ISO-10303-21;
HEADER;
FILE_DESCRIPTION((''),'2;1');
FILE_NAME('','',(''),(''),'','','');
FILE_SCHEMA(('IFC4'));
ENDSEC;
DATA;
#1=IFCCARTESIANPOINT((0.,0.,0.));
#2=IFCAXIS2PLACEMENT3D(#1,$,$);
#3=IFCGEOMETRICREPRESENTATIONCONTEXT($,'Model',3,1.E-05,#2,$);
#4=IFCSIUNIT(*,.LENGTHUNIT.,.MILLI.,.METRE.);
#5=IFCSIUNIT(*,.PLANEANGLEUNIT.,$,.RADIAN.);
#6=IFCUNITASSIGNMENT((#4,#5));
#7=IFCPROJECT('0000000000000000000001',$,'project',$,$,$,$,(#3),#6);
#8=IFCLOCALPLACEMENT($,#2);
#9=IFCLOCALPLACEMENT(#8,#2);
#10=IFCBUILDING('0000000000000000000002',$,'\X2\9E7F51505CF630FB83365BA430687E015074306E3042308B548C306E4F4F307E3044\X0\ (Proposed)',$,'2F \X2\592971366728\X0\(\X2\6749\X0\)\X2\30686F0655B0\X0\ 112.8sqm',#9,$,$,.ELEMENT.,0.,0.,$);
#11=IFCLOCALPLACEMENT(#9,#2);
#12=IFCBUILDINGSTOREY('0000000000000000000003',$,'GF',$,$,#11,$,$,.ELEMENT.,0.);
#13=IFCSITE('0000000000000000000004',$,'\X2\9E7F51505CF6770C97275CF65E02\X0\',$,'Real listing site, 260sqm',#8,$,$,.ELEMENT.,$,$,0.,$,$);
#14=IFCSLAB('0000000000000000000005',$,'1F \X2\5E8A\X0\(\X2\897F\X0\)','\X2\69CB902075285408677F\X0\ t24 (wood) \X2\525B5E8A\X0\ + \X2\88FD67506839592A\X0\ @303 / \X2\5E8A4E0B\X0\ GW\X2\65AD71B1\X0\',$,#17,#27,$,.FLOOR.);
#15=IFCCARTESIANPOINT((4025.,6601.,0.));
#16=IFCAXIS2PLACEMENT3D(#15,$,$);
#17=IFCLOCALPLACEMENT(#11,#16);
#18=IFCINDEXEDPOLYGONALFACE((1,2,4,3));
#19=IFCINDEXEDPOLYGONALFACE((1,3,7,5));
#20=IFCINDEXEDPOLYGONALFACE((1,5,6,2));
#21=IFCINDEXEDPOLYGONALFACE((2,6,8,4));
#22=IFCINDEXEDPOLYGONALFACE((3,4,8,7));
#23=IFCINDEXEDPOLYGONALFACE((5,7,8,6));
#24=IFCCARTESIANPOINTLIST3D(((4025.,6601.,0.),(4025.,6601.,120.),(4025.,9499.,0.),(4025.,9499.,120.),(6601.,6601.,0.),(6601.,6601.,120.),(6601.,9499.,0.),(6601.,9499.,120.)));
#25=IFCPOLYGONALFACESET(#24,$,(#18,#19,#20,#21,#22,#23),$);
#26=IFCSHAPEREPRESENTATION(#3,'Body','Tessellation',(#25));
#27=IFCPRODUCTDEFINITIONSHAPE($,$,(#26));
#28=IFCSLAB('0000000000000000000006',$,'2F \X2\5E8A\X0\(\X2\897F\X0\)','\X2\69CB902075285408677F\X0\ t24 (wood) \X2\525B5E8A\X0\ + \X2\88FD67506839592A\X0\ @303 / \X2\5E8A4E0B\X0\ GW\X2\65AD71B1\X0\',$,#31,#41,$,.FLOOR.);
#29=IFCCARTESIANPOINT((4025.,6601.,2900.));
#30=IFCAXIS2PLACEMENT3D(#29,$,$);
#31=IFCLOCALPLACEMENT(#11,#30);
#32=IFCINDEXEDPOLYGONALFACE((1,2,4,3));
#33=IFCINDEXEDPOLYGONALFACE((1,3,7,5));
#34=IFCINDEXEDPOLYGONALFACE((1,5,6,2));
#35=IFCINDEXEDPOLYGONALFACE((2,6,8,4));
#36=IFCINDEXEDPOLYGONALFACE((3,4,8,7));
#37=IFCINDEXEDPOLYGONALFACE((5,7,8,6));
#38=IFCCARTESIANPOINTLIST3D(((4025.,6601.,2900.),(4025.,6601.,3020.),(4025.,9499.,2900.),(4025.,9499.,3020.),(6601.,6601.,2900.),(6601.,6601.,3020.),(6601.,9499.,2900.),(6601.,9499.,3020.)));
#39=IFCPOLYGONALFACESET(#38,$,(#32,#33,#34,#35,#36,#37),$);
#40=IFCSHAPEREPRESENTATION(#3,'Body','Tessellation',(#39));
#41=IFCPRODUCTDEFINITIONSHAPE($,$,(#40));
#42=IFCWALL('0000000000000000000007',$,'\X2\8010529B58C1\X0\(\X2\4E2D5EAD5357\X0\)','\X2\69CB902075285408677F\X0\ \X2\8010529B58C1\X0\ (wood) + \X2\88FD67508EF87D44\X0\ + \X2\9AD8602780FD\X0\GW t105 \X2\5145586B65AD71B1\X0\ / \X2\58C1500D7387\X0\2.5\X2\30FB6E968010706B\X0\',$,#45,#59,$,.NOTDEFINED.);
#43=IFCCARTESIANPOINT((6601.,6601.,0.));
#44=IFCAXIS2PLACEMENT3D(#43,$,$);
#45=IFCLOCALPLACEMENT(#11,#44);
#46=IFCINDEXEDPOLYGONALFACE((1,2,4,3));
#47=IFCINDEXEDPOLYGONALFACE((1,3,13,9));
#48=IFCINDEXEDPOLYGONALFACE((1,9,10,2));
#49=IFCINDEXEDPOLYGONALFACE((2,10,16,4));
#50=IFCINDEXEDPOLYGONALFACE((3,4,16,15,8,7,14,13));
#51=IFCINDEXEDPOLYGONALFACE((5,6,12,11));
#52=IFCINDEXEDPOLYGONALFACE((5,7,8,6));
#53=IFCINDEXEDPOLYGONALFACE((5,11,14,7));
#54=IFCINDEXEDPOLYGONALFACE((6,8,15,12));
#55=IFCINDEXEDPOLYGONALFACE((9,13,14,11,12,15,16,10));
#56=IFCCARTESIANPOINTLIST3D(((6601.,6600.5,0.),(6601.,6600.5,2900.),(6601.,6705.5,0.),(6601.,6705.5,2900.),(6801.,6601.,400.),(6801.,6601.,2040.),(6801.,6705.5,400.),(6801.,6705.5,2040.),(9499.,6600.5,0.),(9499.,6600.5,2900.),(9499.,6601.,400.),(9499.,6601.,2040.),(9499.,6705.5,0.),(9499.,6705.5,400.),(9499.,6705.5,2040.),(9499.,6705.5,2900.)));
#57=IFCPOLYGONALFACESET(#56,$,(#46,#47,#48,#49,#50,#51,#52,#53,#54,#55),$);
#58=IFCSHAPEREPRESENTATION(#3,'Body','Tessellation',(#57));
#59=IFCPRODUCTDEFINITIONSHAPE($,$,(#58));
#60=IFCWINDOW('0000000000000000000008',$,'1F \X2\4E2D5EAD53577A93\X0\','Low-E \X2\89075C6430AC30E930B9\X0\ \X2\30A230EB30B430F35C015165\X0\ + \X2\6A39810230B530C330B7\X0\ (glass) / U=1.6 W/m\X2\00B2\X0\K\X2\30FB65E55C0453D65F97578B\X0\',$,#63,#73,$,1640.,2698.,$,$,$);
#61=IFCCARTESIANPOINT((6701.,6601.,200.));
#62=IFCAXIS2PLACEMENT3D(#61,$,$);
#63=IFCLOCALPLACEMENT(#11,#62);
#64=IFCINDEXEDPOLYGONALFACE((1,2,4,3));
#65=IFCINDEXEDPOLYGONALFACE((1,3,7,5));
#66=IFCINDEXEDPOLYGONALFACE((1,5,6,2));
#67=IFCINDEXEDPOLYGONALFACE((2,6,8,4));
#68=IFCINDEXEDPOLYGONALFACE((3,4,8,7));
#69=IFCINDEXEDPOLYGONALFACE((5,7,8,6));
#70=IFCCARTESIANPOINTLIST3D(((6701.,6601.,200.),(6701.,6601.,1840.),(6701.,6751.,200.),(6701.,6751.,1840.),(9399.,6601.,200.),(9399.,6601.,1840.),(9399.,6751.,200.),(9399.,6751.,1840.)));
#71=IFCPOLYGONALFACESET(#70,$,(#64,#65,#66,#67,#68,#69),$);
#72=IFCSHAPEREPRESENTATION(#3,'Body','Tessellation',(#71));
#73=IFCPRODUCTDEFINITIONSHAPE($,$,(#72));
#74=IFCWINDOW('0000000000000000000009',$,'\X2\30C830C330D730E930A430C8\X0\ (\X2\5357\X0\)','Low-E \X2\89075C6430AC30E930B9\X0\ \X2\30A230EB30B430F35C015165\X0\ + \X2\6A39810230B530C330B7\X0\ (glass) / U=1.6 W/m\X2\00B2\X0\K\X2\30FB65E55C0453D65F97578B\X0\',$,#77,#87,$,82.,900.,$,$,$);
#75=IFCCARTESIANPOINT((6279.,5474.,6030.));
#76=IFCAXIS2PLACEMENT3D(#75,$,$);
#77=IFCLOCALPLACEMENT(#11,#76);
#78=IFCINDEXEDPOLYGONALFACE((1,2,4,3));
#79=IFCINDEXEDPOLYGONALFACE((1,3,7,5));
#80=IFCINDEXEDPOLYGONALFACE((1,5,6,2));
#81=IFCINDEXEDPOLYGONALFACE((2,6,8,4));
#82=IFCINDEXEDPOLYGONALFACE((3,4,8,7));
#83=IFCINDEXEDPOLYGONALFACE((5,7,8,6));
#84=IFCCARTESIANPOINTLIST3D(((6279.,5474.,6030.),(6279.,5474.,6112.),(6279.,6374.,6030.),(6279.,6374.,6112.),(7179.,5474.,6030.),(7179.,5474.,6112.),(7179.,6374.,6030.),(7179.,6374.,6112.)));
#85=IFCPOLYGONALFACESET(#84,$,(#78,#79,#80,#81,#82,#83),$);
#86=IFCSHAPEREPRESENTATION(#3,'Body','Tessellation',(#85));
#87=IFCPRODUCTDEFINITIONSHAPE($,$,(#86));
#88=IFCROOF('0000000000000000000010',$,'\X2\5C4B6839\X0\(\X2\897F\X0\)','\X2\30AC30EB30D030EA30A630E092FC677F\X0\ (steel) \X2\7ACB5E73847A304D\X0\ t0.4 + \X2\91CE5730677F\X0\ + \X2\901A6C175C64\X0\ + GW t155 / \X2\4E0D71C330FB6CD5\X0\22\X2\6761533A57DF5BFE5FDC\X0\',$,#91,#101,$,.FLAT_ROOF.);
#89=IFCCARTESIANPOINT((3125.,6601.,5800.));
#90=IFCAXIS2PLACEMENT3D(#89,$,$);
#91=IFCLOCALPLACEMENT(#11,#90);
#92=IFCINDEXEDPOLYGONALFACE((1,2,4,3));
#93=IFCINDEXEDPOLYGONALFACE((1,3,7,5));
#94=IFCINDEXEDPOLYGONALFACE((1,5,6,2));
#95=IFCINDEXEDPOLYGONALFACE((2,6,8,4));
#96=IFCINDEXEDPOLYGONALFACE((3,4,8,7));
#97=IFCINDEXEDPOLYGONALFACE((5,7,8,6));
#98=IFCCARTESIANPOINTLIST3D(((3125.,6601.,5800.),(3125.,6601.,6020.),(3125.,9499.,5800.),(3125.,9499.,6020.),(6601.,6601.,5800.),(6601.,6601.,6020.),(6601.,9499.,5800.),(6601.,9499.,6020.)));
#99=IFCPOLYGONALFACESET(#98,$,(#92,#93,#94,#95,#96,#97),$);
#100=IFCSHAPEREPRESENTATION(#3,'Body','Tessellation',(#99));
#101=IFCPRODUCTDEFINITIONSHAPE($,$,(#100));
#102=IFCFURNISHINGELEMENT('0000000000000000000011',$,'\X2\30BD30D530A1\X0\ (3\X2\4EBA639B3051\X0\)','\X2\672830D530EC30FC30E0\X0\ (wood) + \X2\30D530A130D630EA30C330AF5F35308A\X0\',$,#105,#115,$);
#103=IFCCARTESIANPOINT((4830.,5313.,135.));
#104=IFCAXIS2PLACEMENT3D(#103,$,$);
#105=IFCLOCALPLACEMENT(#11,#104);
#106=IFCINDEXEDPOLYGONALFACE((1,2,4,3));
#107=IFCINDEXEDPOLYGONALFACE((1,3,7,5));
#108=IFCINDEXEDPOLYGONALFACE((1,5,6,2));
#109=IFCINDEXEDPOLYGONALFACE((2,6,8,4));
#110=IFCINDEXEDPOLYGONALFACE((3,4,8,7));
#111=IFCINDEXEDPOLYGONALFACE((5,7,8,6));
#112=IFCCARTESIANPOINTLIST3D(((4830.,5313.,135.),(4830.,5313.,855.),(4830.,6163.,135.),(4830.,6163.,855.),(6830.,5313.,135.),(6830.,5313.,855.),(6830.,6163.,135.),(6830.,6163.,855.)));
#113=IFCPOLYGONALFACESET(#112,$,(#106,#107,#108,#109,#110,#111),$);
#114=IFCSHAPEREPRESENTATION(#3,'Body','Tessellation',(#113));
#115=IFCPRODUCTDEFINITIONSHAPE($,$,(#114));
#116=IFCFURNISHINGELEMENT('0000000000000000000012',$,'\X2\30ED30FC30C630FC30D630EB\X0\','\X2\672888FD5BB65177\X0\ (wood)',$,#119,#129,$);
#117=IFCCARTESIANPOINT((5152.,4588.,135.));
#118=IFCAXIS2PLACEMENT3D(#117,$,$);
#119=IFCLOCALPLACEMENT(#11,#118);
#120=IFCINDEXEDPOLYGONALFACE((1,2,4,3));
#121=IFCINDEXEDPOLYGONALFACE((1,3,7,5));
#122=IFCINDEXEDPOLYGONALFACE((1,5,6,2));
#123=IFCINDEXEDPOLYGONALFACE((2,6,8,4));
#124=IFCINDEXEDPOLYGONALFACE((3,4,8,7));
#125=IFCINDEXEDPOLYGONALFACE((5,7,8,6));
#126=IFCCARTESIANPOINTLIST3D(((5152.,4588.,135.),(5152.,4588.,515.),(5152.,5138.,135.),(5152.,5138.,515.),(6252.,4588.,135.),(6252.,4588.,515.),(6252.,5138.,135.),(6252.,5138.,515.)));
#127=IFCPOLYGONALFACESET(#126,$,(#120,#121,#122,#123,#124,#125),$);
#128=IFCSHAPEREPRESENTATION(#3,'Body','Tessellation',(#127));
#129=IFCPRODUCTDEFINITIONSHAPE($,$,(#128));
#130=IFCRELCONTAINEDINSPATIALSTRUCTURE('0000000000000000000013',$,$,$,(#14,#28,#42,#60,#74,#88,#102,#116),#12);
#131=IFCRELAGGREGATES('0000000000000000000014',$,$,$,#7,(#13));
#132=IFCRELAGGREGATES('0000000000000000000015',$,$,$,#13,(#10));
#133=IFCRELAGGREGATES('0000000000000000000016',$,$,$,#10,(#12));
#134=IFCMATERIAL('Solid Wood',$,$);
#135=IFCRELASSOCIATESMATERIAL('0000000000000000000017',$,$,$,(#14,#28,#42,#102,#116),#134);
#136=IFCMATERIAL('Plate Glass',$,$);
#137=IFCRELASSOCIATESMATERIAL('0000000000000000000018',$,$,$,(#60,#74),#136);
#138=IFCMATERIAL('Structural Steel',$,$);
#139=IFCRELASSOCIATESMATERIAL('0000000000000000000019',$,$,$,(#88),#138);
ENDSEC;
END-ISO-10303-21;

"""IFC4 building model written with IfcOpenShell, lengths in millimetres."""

from ifc_helpers import new_model, si_unit, frame, frame_2d, origin, place, context, project, spatial, rectangle, extrude, material, element, fill, save


model = new_model("IFC4")

# Units and contexts
model_context = context("Model", 3, precision=1e-05, world=origin())
ifc_project = project(units=[si_unit("LENGTHUNIT", "METRE", prefix="MILLI"), si_unit("PLANEANGLEUNIT", "RADIAN")], contexts=[model_context])

# Site, building, storey
site_placement = place(None, origin())
site = spatial("IfcSite", under=ifc_project, at=site_placement, Name="鹿児島県霧島市", ObjectType="Real listing site, 260sqm", CompositionType="ELEMENT", RefElevation=0.0)
building_placement = place(site_placement, origin())
building = spatial("IfcBuilding", under=site, at=building_placement, Name="鹿児島・茶室と縁側のある和の住まい (Proposed)", ObjectType="2F 天然木(杉)と漆喰 112.8sqm", CompositionType="ELEMENT", ElevationOfRefHeight=0.0, ElevationOfTerrain=0.0)
storey_placement = place(building_placement, origin())
storey = spatial("IfcBuildingStorey", under=building, at=storey_placement, Name="GF", CompositionType="ELEMENT", Elevation=0.0)

# Shared definitions
ifc_material_1 = material(Name="Solid Wood")

# Slabs
slab_1_placement = place(storey_placement, frame((4025.0, 6601.0, 0.0)))
element("IfcSlab", 1, at=slab_1_placement, inside=storey, material=ifc_material_1, Name="1F 床(西)", Description="構造用合板 t24 (wood) 剛床 + 製材根太 @303 / 床下 GW断熱", PredefinedType="FLOOR", context=model_context, shape_type="SweptSolid", body=[
    extrude(rectangle(XDim=2576.0, YDim=2898.0, at=frame_2d((1288.0, 1449.0))), frame((4025.0, 6601.0, 0.0)), (0.0, 0.0, 1.0), 120.0),
])
slab_2_placement = place(storey_placement, frame((4025.0, 6601.0, 2900.0)))
element("IfcSlab", 2, at=slab_2_placement, inside=storey, material=ifc_material_1, Name="2F 床(西)", Description="構造用合板 t24 (wood) 剛床 + 製材根太 @303 / 床下 GW断熱", PredefinedType="FLOOR", context=model_context, shape_type="SweptSolid", body=[
    extrude(rectangle(XDim=2576.0, YDim=2898.0, at=frame_2d((1288.0, 1449.0))), frame((4025.0, 6601.0, 2900.0)), (0.0, 0.0, 1.0), 120.0),
])

# Wall, opening, window
wall_placement = place(storey_placement, frame((6601.0, 6601.0, 0.0)))
wall = element("IfcWall", 3, at=wall_placement, inside=storey, material=ifc_material_1, Name="耐力壁(中庭南)", Description="構造用合板 耐力壁 (wood) + 製材軸組 + 高性能GW t105 充填断熱 / 壁倍率2.5・準耐火", PredefinedType="NOTDEFINED", context=model_context, shape_type="SweptSolid", body=[
    extrude(rectangle(XDim=2898.0, YDim=105.0, at=frame_2d((1449.0, 52.0))), frame((6601.0, 6601.0, 0.0)), (0.0, 0.0, 1.0), 2900.0),
])
opening_placement = place(storey_placement, frame((6701.0, 6601.0, 200.0)))
opening = element("IfcOpeningElement", 4, at=opening_placement, cuts=wall, PredefinedType="NOTDEFINED", context=model_context, shape_type="SweptSolid", body=[
    extrude(rectangle(XDim=2698.0, YDim=150.0, at=frame_2d((1349.0, 75.0))), frame((6701.0, 6601.0, 200.0)), (0.0, 0.0, 1.0), 1640.0),
])
ifc_material_2 = material(Name="Plate Glass")
window_1_placement = place(storey_placement, frame((6701.0, 6601.0, 200.0)))
window_1 = element("IfcWindow", 5, at=window_1_placement, inside=storey, material=ifc_material_2, Name="1F 中庭南窓", Description="Low-E 複層ガラス アルゴン封入 + 樹脂サッシ (glass) / U=1.6 W/m²K・日射取得型", OverallHeight=1640.0, OverallWidth=2698.0, context=model_context, shape_type="SweptSolid", body=[
    extrude(rectangle(XDim=2698.0, YDim=150.0, at=frame_2d((1349.0, 75.0))), frame((6701.0, 6601.0, 200.0)), (0.0, 0.0, 1.0), 1640.0),
])
fill(opening, window_1)

# Window
window_2_placement = place(storey_placement, frame((6279.0, 5474.0, 6030.0)))
element("IfcWindow", 6, at=window_2_placement, inside=storey, material=ifc_material_2, Name="トップライト (南)", Description="Low-E 複層ガラス アルゴン封入 + 樹脂サッシ (glass) / U=1.6 W/m²K・日射取得型", OverallHeight=82.0, OverallWidth=900.0, context=model_context, shape_type="SweptSolid", body=[
    extrude(rectangle(XDim=900.0, YDim=900.0, at=frame_2d((450.0, 450.0))), frame((6279.0, 5474.0, 6030.0)), (0.0, 0.0, 1.0), 82.0),
])

# Roof
ifc_material_3 = material(Name="Structural Steel")
for number, where, name in (
    (7, (3125.0, 6601.0, 5800.0), "屋根(西)"),
):
    element("IfcRoof", number, at=place(storey_placement, frame(where)), inside=storey, material=ifc_material_3, Name=name, Description="ガルバリウム鋼板 (steel) 立平葺き t0.4 + 野地板 + 通気層 + GW t155 / 不燃・法22条区域対応", PredefinedType="FLAT_ROOF", context=model_context, shape_type="SweptSolid", body=[
        extrude(rectangle(XDim=3476.0, YDim=2898.0, at=frame_2d((1738.0, 1449.0))), frame((3125.0, 6601.0, 5800.0)), (0.0, 0.0, 1.0), 220.0),
    ])

# Furnishing elements
furnishing_1_placement = place(storey_placement, frame((4830.0, 5313.0, 135.0)))
element("IfcFurnishingElement", 8, at=furnishing_1_placement, inside=storey, material=ifc_material_1, Name="ソファ (3人掛け)", Description="木フレーム (wood) + ファブリック張り", context=model_context, shape_type="SweptSolid", body=[
    extrude(rectangle(XDim=2000.0, YDim=850.0, at=frame_2d((1000.0, 425.0))), frame((4830.0, 5313.0, 135.0)), (0.0, 0.0, 1.0), 720.0),
])
furnishing_2_placement = place(storey_placement, frame((5152.0, 4588.0, 135.0)))
element("IfcFurnishingElement", 9, at=furnishing_2_placement, inside=storey, material=ifc_material_1, Name="ローテーブル", Description="木製家具 (wood)", context=model_context, shape_type="SweptSolid", body=[
    extrude(rectangle(XDim=1100.0, YDim=550.0, at=frame_2d((550.0, 275.0))), frame((5152.0, 4588.0, 135.0)), (0.0, 0.0, 1.0), 380.0),
])

save(model, "model.ifc")
